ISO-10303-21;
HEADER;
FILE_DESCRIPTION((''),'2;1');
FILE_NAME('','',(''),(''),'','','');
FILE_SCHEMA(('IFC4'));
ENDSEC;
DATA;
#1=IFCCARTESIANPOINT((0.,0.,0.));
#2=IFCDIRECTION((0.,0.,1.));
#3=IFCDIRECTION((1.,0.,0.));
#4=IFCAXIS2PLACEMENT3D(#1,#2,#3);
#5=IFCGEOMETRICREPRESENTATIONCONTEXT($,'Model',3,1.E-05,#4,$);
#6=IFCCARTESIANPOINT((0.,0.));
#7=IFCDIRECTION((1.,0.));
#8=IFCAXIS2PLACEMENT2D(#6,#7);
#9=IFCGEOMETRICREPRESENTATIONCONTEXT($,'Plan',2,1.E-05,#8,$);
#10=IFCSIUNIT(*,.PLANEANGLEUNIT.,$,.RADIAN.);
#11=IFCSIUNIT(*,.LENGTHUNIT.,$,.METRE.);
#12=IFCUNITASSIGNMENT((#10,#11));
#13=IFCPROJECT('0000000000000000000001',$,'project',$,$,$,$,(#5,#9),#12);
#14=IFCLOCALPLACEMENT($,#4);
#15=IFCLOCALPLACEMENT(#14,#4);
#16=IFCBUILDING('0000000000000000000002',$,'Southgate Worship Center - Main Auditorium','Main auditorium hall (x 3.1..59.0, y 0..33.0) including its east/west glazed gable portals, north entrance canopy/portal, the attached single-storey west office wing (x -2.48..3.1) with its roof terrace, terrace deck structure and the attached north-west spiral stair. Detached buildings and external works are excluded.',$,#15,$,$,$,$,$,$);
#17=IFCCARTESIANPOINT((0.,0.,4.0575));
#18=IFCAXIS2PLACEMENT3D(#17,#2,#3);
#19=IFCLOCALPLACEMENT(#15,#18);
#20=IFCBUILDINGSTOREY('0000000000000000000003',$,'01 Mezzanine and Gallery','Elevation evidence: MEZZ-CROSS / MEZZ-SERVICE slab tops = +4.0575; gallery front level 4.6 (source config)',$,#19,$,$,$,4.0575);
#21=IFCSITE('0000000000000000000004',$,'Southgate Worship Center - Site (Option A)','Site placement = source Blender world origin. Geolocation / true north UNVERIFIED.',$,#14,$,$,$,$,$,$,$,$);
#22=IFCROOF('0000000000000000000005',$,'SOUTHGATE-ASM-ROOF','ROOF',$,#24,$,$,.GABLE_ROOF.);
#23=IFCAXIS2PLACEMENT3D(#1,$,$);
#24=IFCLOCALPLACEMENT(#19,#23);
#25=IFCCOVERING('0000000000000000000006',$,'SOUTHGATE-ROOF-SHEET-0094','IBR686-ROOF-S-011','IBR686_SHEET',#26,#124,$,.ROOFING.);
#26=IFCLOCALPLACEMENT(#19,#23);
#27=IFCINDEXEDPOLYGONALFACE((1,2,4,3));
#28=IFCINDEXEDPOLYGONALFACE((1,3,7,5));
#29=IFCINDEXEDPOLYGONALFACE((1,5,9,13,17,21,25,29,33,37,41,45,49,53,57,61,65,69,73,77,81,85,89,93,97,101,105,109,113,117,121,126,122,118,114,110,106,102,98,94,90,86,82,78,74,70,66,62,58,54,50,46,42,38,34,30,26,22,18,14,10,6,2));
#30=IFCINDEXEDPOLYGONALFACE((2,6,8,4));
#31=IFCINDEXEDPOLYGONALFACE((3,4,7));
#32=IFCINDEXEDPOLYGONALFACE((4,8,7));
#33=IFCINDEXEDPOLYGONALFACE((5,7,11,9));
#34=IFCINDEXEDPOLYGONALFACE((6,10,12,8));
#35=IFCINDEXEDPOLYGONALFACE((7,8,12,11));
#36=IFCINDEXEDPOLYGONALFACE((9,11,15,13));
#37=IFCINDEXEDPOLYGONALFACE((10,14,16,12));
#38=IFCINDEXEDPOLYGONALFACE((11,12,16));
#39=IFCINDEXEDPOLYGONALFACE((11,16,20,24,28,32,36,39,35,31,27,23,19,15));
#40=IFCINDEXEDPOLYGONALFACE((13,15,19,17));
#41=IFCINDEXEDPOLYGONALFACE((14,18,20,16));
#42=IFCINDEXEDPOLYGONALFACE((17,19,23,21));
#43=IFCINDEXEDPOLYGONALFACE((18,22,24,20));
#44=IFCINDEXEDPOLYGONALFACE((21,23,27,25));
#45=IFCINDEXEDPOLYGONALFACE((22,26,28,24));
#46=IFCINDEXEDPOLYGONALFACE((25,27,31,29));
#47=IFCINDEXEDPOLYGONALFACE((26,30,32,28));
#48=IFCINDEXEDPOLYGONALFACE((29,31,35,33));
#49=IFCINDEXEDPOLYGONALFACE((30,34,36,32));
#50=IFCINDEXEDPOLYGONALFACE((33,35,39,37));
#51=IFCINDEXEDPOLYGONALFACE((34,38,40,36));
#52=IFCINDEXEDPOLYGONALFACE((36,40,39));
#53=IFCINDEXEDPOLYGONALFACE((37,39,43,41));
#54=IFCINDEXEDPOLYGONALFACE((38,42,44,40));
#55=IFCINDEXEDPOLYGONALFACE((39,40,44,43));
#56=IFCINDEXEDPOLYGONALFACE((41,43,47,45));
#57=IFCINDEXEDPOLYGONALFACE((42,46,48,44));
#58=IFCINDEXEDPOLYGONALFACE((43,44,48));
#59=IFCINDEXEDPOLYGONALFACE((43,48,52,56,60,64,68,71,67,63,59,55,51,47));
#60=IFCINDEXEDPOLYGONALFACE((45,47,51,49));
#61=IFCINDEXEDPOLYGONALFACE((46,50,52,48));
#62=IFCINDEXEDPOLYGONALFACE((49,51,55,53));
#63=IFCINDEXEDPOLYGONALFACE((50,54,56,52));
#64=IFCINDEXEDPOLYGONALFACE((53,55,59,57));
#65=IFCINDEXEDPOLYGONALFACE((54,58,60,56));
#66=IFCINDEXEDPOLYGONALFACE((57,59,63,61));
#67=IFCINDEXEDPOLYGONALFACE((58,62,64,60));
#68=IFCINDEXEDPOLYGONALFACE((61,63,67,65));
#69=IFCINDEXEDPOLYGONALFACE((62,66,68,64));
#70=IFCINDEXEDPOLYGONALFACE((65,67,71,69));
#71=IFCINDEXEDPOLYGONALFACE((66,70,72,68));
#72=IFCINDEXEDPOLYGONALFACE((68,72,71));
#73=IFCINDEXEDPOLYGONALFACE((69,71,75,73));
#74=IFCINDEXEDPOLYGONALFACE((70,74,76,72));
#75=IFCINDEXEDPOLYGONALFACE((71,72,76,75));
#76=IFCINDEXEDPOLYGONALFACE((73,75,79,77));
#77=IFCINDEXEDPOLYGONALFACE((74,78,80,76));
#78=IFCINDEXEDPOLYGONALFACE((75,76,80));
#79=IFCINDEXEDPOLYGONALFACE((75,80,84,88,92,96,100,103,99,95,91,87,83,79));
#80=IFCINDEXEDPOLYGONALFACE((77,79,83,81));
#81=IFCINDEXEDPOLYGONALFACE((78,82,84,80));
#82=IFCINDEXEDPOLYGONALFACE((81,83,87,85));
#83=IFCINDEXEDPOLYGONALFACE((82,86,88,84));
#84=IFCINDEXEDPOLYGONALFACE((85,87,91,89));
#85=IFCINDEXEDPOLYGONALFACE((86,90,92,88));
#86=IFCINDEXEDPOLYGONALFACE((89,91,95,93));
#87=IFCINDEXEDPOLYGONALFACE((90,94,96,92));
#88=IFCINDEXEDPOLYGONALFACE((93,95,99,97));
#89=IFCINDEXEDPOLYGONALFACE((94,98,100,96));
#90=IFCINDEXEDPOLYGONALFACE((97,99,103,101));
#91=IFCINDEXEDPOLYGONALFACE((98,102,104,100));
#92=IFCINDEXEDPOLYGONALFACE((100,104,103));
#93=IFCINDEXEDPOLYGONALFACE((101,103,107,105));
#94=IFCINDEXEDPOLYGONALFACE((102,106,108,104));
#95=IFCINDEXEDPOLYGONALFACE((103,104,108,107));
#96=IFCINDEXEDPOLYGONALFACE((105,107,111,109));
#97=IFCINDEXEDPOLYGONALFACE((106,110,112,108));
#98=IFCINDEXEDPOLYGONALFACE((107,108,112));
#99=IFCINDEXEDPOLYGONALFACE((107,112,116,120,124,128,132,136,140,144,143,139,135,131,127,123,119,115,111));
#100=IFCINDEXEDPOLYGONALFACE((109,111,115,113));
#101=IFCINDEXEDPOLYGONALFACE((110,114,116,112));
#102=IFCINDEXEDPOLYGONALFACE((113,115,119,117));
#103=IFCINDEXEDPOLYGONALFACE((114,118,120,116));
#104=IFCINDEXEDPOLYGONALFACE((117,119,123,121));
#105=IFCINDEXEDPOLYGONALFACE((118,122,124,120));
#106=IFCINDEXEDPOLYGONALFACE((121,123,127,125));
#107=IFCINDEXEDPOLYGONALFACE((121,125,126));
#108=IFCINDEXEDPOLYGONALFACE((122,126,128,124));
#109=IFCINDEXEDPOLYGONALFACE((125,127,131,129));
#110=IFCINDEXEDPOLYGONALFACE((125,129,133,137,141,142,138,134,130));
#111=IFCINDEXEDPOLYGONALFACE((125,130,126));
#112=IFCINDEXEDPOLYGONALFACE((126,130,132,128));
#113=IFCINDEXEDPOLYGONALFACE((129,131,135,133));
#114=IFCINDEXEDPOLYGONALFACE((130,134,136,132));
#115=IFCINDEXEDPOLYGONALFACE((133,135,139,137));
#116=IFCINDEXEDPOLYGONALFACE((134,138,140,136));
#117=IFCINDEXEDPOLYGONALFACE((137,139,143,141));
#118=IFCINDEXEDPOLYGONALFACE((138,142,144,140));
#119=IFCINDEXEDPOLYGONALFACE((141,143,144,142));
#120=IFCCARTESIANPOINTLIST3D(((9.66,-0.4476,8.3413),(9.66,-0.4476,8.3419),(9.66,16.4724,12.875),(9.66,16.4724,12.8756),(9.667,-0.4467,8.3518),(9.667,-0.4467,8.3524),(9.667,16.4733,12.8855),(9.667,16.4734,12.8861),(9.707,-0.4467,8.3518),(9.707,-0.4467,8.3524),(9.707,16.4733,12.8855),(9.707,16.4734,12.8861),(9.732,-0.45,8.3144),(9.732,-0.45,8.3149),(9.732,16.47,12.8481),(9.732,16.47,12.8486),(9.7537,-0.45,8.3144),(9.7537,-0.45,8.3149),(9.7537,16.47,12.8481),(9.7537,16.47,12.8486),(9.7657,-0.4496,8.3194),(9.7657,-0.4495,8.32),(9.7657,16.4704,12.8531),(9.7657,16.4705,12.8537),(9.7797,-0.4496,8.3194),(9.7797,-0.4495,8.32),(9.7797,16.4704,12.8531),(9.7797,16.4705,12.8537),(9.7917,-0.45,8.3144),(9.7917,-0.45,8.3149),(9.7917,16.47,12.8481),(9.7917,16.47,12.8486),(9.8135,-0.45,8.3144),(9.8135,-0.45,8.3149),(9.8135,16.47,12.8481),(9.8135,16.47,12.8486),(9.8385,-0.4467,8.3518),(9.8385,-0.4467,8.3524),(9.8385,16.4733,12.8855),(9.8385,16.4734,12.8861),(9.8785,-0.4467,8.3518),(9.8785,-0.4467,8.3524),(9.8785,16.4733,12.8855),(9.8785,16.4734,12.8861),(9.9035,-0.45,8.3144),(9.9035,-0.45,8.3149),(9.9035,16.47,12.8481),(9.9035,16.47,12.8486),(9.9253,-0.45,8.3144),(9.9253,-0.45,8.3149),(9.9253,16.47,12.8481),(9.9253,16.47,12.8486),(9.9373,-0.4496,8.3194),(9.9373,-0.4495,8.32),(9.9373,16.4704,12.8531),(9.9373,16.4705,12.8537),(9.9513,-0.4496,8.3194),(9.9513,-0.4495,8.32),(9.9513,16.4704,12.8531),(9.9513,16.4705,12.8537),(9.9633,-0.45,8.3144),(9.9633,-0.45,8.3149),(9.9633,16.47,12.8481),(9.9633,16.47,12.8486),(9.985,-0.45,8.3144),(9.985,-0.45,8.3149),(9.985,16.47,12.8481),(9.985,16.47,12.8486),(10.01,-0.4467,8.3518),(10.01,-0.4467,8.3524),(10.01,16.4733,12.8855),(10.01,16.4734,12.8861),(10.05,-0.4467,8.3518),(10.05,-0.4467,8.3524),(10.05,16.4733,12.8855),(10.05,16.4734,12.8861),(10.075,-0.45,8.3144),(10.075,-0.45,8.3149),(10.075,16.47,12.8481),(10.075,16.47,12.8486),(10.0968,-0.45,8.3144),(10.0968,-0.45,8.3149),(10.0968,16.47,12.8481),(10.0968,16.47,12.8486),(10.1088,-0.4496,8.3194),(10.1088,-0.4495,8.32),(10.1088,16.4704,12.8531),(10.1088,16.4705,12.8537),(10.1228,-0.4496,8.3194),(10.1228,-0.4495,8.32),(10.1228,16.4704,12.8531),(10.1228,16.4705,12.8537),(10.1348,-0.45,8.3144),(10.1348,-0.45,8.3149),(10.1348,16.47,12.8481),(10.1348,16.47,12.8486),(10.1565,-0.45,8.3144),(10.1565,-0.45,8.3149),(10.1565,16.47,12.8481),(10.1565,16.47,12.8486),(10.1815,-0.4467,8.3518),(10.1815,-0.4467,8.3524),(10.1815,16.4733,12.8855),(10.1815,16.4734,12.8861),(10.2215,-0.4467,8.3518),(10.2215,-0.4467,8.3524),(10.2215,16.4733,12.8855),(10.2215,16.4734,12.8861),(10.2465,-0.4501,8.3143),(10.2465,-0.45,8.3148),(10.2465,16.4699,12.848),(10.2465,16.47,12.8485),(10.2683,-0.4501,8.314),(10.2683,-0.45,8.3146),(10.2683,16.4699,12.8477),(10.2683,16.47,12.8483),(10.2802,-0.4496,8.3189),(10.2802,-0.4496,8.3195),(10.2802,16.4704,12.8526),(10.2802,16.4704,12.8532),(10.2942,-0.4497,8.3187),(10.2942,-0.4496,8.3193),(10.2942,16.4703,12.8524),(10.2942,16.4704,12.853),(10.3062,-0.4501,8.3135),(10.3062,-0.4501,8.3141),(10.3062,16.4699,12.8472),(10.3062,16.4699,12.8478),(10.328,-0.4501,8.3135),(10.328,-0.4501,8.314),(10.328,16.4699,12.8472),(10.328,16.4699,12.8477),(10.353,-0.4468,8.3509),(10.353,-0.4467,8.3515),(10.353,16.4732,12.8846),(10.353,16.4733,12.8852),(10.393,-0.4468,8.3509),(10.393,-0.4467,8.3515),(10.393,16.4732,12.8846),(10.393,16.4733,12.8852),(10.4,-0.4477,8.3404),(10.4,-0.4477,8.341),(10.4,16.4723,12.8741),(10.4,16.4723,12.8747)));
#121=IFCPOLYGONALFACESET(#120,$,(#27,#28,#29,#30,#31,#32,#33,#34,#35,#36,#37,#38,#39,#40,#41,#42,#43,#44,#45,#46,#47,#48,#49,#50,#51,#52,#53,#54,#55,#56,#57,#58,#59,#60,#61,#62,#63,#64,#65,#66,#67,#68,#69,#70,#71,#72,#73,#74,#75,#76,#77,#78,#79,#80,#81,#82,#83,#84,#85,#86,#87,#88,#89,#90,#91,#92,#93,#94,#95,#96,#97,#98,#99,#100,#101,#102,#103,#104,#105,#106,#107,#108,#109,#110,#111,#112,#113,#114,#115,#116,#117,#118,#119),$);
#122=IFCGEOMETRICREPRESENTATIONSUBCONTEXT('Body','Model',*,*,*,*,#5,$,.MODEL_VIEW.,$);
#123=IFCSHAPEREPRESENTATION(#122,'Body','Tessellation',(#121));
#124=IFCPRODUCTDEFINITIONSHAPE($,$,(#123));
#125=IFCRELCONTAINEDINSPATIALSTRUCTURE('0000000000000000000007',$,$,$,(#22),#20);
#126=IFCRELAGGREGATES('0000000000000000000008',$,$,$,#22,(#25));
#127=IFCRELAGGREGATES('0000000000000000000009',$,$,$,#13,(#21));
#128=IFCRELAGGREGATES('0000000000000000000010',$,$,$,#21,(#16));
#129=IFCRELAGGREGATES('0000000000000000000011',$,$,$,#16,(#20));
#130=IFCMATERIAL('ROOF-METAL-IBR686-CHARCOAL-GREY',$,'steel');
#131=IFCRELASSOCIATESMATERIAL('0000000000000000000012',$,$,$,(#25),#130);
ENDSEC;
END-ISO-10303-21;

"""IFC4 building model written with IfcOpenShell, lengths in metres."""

from ifc_helpers import new_model, si_unit, frame, origin_with_axes, origin_2d_with_axis, place, context, subcontext, project, spatial, indexed_curve, outline, extrude, clip, halfspace, material, element, aggregate, save


model = new_model("IFC4")

# Units and contexts
model_context = context("Model", 3, precision=1e-05, world=origin_with_axes())
plan_context = context("Plan", 2, precision=1e-05, world=origin_2d_with_axis())
body_context = subcontext(model_context, "Body", "Model", "MODEL_VIEW")
ifc_project = project(units=[si_unit("PLANEANGLEUNIT", "RADIAN"), si_unit("LENGTHUNIT", "METRE")], contexts=[model_context, plan_context])

# Site, building, storey
site_placement = place(None, origin_with_axes())
site = spatial("IfcSite", under=ifc_project, at=site_placement, Name="Southgate Worship Center - Site (Option A)", Description="Site placement = source Blender world origin. Geolocation / true north UNVERIFIED.")
building_placement = place(site_placement, origin_with_axes())
building = spatial("IfcBuilding", under=site, at=building_placement, Name="Southgate Worship Center - Main Auditorium", Description="Main auditorium hall (x 3.1..59.0, y 0..33.0) including its east/west glazed gable portals, north entrance canopy/portal, the attached single-storey west office wing (x -2.48..3.1) with its roof terrace, terrace deck structure and the attached north-west spiral stair. Detached buildings and external works are excluded.")
storey_placement = place(building_placement, frame((0.0, 0.0, 4.0575), z_axis=(0.0, 0.0, 1.0), x_axis=(1.0, 0.0, 0.0)))
storey = spatial("IfcBuildingStorey", under=building, at=storey_placement, Name="01 Mezzanine and Gallery", Description="Elevation evidence: MEZZ-CROSS / MEZZ-SERVICE slab tops = +4.0575; gallery front level 4.6 (source config)", Elevation=4.0575)

# Roof, covering
roof_placement = place(storey_placement, origin_with_axes())
roof = element("IfcRoof", 1, at=roof_placement, inside=storey, Name="SOUTHGATE-ASM-ROOF", Description="ROOF", PredefinedType="GABLE_ROOF")
ifc_material_1 = material(Name="ROOF-METAL-IBR686-CHARCOAL-GREY", Category="steel")
covering_1_placement = place(roof_placement, frame((9.66, -0.4501, 8.3135), z_axis=(0.0, 0.0, 1.0), x_axis=(1.0, 0.0, 0.0)))
covering_1 = element("IfcCovering", 2, at=covering_1_placement, material=ifc_material_1, Name="SOUTHGATE-ROOF-SHEET-0094", Description="IBR686-ROOF-S-011", ObjectType="IBR686_SHEET", PredefinedType="ROOFING", context=body_context, shape_type="Clipping", body=[
    clip(clip(extrude(outline(indexed_curve([(0.0, 0.0), (0.025, 0.0353), (0.065, 0.0353), (0.072, 0.0254), (0.072, 0.0259), (0.065, 0.0358), (0.025, 0.0358), (0.0, 0.0005), (-0.0217, 0.0005), (-0.0337, 0.0053), (-0.0477, 0.0053), (-0.0597, 0.0005), (-0.0815, 0.0005), (-0.1065, 0.0358), (-0.1465, 0.0358), (-0.1715, 0.0005), (-0.1932, 0.0005), (-0.2052, 0.0053), (-0.2192, 0.0053), (-0.2312, 0.0005), (-0.253, 0.0005), (-0.278, 0.0358), (-0.318, 0.0358), (-0.343, 0.0005), (-0.3647, 0.0005), (-0.3767, 0.0053), (-0.3907, 0.0053), (-0.4028, 0.0005), (-0.4245, 0.0005), (-0.4495, 0.0358), (-0.4895, 0.0358), (-0.5145, 0.0004), (-0.5363, 0.0002), (-0.5482, 0.0048), (-0.5622, 0.0046), (-0.5742, -0.0003), (-0.596, -0.0004), (-0.621, 0.0349), (-0.661, 0.0349), (-0.668, 0.0251), (-0.668, 0.0246), (-0.661, 0.0344), (-0.621, 0.0344), (-0.596, -0.0009), (-0.5742, -0.0008), (-0.5622, 0.0041), (-0.5482, 0.0043), (-0.5363, -0.0003), (-0.5145, -0.0001), (-0.4895, 0.0353), (-0.4495, 0.0353), (-0.4245, 0.0), (-0.4028, 0.0), (-0.3907, 0.0048), (-0.3767, 0.0048), (-0.3647, 0.0), (-0.343, 0.0), (-0.318, 0.0353), (-0.278, 0.0353), (-0.253, 0.0), (-0.2312, 0.0), (-0.2192, 0.0048), (-0.2052, 0.0048), (-0.1932, 0.0), (-0.1715, 0.0), (-0.1465, 0.0353), (-0.1065, 0.0353), (-0.0815, 0.0), (-0.0597, 0.0), (-0.0477, 0.0048), (-0.0337, 0.0048), (-0.0217, 0.0), (0.0, 0.0)], self_intersect=False)), frame((0.072, -0.0003, 0.0008), z_axis=(0.0, 0.965926, 0.258819), x_axis=(-1.0, 0.0, 0.0)), (0.0, 0.0, 1.0), 17.5303), halfspace(frame((0.37, 0.0012, 0.014), z_axis=(0.0, -0.996022, 0.089113), x_axis=(1.0, 0.0, 0.0)), False)), halfspace(frame((0.37, 16.9212, 4.5477), z_axis=(0.0, 0.996021, -0.089119), x_axis=(-1.0, 0.0, 0.0)), False)),
])
aggregate(roof, [covering_1])

save(model, "model.ifc")
